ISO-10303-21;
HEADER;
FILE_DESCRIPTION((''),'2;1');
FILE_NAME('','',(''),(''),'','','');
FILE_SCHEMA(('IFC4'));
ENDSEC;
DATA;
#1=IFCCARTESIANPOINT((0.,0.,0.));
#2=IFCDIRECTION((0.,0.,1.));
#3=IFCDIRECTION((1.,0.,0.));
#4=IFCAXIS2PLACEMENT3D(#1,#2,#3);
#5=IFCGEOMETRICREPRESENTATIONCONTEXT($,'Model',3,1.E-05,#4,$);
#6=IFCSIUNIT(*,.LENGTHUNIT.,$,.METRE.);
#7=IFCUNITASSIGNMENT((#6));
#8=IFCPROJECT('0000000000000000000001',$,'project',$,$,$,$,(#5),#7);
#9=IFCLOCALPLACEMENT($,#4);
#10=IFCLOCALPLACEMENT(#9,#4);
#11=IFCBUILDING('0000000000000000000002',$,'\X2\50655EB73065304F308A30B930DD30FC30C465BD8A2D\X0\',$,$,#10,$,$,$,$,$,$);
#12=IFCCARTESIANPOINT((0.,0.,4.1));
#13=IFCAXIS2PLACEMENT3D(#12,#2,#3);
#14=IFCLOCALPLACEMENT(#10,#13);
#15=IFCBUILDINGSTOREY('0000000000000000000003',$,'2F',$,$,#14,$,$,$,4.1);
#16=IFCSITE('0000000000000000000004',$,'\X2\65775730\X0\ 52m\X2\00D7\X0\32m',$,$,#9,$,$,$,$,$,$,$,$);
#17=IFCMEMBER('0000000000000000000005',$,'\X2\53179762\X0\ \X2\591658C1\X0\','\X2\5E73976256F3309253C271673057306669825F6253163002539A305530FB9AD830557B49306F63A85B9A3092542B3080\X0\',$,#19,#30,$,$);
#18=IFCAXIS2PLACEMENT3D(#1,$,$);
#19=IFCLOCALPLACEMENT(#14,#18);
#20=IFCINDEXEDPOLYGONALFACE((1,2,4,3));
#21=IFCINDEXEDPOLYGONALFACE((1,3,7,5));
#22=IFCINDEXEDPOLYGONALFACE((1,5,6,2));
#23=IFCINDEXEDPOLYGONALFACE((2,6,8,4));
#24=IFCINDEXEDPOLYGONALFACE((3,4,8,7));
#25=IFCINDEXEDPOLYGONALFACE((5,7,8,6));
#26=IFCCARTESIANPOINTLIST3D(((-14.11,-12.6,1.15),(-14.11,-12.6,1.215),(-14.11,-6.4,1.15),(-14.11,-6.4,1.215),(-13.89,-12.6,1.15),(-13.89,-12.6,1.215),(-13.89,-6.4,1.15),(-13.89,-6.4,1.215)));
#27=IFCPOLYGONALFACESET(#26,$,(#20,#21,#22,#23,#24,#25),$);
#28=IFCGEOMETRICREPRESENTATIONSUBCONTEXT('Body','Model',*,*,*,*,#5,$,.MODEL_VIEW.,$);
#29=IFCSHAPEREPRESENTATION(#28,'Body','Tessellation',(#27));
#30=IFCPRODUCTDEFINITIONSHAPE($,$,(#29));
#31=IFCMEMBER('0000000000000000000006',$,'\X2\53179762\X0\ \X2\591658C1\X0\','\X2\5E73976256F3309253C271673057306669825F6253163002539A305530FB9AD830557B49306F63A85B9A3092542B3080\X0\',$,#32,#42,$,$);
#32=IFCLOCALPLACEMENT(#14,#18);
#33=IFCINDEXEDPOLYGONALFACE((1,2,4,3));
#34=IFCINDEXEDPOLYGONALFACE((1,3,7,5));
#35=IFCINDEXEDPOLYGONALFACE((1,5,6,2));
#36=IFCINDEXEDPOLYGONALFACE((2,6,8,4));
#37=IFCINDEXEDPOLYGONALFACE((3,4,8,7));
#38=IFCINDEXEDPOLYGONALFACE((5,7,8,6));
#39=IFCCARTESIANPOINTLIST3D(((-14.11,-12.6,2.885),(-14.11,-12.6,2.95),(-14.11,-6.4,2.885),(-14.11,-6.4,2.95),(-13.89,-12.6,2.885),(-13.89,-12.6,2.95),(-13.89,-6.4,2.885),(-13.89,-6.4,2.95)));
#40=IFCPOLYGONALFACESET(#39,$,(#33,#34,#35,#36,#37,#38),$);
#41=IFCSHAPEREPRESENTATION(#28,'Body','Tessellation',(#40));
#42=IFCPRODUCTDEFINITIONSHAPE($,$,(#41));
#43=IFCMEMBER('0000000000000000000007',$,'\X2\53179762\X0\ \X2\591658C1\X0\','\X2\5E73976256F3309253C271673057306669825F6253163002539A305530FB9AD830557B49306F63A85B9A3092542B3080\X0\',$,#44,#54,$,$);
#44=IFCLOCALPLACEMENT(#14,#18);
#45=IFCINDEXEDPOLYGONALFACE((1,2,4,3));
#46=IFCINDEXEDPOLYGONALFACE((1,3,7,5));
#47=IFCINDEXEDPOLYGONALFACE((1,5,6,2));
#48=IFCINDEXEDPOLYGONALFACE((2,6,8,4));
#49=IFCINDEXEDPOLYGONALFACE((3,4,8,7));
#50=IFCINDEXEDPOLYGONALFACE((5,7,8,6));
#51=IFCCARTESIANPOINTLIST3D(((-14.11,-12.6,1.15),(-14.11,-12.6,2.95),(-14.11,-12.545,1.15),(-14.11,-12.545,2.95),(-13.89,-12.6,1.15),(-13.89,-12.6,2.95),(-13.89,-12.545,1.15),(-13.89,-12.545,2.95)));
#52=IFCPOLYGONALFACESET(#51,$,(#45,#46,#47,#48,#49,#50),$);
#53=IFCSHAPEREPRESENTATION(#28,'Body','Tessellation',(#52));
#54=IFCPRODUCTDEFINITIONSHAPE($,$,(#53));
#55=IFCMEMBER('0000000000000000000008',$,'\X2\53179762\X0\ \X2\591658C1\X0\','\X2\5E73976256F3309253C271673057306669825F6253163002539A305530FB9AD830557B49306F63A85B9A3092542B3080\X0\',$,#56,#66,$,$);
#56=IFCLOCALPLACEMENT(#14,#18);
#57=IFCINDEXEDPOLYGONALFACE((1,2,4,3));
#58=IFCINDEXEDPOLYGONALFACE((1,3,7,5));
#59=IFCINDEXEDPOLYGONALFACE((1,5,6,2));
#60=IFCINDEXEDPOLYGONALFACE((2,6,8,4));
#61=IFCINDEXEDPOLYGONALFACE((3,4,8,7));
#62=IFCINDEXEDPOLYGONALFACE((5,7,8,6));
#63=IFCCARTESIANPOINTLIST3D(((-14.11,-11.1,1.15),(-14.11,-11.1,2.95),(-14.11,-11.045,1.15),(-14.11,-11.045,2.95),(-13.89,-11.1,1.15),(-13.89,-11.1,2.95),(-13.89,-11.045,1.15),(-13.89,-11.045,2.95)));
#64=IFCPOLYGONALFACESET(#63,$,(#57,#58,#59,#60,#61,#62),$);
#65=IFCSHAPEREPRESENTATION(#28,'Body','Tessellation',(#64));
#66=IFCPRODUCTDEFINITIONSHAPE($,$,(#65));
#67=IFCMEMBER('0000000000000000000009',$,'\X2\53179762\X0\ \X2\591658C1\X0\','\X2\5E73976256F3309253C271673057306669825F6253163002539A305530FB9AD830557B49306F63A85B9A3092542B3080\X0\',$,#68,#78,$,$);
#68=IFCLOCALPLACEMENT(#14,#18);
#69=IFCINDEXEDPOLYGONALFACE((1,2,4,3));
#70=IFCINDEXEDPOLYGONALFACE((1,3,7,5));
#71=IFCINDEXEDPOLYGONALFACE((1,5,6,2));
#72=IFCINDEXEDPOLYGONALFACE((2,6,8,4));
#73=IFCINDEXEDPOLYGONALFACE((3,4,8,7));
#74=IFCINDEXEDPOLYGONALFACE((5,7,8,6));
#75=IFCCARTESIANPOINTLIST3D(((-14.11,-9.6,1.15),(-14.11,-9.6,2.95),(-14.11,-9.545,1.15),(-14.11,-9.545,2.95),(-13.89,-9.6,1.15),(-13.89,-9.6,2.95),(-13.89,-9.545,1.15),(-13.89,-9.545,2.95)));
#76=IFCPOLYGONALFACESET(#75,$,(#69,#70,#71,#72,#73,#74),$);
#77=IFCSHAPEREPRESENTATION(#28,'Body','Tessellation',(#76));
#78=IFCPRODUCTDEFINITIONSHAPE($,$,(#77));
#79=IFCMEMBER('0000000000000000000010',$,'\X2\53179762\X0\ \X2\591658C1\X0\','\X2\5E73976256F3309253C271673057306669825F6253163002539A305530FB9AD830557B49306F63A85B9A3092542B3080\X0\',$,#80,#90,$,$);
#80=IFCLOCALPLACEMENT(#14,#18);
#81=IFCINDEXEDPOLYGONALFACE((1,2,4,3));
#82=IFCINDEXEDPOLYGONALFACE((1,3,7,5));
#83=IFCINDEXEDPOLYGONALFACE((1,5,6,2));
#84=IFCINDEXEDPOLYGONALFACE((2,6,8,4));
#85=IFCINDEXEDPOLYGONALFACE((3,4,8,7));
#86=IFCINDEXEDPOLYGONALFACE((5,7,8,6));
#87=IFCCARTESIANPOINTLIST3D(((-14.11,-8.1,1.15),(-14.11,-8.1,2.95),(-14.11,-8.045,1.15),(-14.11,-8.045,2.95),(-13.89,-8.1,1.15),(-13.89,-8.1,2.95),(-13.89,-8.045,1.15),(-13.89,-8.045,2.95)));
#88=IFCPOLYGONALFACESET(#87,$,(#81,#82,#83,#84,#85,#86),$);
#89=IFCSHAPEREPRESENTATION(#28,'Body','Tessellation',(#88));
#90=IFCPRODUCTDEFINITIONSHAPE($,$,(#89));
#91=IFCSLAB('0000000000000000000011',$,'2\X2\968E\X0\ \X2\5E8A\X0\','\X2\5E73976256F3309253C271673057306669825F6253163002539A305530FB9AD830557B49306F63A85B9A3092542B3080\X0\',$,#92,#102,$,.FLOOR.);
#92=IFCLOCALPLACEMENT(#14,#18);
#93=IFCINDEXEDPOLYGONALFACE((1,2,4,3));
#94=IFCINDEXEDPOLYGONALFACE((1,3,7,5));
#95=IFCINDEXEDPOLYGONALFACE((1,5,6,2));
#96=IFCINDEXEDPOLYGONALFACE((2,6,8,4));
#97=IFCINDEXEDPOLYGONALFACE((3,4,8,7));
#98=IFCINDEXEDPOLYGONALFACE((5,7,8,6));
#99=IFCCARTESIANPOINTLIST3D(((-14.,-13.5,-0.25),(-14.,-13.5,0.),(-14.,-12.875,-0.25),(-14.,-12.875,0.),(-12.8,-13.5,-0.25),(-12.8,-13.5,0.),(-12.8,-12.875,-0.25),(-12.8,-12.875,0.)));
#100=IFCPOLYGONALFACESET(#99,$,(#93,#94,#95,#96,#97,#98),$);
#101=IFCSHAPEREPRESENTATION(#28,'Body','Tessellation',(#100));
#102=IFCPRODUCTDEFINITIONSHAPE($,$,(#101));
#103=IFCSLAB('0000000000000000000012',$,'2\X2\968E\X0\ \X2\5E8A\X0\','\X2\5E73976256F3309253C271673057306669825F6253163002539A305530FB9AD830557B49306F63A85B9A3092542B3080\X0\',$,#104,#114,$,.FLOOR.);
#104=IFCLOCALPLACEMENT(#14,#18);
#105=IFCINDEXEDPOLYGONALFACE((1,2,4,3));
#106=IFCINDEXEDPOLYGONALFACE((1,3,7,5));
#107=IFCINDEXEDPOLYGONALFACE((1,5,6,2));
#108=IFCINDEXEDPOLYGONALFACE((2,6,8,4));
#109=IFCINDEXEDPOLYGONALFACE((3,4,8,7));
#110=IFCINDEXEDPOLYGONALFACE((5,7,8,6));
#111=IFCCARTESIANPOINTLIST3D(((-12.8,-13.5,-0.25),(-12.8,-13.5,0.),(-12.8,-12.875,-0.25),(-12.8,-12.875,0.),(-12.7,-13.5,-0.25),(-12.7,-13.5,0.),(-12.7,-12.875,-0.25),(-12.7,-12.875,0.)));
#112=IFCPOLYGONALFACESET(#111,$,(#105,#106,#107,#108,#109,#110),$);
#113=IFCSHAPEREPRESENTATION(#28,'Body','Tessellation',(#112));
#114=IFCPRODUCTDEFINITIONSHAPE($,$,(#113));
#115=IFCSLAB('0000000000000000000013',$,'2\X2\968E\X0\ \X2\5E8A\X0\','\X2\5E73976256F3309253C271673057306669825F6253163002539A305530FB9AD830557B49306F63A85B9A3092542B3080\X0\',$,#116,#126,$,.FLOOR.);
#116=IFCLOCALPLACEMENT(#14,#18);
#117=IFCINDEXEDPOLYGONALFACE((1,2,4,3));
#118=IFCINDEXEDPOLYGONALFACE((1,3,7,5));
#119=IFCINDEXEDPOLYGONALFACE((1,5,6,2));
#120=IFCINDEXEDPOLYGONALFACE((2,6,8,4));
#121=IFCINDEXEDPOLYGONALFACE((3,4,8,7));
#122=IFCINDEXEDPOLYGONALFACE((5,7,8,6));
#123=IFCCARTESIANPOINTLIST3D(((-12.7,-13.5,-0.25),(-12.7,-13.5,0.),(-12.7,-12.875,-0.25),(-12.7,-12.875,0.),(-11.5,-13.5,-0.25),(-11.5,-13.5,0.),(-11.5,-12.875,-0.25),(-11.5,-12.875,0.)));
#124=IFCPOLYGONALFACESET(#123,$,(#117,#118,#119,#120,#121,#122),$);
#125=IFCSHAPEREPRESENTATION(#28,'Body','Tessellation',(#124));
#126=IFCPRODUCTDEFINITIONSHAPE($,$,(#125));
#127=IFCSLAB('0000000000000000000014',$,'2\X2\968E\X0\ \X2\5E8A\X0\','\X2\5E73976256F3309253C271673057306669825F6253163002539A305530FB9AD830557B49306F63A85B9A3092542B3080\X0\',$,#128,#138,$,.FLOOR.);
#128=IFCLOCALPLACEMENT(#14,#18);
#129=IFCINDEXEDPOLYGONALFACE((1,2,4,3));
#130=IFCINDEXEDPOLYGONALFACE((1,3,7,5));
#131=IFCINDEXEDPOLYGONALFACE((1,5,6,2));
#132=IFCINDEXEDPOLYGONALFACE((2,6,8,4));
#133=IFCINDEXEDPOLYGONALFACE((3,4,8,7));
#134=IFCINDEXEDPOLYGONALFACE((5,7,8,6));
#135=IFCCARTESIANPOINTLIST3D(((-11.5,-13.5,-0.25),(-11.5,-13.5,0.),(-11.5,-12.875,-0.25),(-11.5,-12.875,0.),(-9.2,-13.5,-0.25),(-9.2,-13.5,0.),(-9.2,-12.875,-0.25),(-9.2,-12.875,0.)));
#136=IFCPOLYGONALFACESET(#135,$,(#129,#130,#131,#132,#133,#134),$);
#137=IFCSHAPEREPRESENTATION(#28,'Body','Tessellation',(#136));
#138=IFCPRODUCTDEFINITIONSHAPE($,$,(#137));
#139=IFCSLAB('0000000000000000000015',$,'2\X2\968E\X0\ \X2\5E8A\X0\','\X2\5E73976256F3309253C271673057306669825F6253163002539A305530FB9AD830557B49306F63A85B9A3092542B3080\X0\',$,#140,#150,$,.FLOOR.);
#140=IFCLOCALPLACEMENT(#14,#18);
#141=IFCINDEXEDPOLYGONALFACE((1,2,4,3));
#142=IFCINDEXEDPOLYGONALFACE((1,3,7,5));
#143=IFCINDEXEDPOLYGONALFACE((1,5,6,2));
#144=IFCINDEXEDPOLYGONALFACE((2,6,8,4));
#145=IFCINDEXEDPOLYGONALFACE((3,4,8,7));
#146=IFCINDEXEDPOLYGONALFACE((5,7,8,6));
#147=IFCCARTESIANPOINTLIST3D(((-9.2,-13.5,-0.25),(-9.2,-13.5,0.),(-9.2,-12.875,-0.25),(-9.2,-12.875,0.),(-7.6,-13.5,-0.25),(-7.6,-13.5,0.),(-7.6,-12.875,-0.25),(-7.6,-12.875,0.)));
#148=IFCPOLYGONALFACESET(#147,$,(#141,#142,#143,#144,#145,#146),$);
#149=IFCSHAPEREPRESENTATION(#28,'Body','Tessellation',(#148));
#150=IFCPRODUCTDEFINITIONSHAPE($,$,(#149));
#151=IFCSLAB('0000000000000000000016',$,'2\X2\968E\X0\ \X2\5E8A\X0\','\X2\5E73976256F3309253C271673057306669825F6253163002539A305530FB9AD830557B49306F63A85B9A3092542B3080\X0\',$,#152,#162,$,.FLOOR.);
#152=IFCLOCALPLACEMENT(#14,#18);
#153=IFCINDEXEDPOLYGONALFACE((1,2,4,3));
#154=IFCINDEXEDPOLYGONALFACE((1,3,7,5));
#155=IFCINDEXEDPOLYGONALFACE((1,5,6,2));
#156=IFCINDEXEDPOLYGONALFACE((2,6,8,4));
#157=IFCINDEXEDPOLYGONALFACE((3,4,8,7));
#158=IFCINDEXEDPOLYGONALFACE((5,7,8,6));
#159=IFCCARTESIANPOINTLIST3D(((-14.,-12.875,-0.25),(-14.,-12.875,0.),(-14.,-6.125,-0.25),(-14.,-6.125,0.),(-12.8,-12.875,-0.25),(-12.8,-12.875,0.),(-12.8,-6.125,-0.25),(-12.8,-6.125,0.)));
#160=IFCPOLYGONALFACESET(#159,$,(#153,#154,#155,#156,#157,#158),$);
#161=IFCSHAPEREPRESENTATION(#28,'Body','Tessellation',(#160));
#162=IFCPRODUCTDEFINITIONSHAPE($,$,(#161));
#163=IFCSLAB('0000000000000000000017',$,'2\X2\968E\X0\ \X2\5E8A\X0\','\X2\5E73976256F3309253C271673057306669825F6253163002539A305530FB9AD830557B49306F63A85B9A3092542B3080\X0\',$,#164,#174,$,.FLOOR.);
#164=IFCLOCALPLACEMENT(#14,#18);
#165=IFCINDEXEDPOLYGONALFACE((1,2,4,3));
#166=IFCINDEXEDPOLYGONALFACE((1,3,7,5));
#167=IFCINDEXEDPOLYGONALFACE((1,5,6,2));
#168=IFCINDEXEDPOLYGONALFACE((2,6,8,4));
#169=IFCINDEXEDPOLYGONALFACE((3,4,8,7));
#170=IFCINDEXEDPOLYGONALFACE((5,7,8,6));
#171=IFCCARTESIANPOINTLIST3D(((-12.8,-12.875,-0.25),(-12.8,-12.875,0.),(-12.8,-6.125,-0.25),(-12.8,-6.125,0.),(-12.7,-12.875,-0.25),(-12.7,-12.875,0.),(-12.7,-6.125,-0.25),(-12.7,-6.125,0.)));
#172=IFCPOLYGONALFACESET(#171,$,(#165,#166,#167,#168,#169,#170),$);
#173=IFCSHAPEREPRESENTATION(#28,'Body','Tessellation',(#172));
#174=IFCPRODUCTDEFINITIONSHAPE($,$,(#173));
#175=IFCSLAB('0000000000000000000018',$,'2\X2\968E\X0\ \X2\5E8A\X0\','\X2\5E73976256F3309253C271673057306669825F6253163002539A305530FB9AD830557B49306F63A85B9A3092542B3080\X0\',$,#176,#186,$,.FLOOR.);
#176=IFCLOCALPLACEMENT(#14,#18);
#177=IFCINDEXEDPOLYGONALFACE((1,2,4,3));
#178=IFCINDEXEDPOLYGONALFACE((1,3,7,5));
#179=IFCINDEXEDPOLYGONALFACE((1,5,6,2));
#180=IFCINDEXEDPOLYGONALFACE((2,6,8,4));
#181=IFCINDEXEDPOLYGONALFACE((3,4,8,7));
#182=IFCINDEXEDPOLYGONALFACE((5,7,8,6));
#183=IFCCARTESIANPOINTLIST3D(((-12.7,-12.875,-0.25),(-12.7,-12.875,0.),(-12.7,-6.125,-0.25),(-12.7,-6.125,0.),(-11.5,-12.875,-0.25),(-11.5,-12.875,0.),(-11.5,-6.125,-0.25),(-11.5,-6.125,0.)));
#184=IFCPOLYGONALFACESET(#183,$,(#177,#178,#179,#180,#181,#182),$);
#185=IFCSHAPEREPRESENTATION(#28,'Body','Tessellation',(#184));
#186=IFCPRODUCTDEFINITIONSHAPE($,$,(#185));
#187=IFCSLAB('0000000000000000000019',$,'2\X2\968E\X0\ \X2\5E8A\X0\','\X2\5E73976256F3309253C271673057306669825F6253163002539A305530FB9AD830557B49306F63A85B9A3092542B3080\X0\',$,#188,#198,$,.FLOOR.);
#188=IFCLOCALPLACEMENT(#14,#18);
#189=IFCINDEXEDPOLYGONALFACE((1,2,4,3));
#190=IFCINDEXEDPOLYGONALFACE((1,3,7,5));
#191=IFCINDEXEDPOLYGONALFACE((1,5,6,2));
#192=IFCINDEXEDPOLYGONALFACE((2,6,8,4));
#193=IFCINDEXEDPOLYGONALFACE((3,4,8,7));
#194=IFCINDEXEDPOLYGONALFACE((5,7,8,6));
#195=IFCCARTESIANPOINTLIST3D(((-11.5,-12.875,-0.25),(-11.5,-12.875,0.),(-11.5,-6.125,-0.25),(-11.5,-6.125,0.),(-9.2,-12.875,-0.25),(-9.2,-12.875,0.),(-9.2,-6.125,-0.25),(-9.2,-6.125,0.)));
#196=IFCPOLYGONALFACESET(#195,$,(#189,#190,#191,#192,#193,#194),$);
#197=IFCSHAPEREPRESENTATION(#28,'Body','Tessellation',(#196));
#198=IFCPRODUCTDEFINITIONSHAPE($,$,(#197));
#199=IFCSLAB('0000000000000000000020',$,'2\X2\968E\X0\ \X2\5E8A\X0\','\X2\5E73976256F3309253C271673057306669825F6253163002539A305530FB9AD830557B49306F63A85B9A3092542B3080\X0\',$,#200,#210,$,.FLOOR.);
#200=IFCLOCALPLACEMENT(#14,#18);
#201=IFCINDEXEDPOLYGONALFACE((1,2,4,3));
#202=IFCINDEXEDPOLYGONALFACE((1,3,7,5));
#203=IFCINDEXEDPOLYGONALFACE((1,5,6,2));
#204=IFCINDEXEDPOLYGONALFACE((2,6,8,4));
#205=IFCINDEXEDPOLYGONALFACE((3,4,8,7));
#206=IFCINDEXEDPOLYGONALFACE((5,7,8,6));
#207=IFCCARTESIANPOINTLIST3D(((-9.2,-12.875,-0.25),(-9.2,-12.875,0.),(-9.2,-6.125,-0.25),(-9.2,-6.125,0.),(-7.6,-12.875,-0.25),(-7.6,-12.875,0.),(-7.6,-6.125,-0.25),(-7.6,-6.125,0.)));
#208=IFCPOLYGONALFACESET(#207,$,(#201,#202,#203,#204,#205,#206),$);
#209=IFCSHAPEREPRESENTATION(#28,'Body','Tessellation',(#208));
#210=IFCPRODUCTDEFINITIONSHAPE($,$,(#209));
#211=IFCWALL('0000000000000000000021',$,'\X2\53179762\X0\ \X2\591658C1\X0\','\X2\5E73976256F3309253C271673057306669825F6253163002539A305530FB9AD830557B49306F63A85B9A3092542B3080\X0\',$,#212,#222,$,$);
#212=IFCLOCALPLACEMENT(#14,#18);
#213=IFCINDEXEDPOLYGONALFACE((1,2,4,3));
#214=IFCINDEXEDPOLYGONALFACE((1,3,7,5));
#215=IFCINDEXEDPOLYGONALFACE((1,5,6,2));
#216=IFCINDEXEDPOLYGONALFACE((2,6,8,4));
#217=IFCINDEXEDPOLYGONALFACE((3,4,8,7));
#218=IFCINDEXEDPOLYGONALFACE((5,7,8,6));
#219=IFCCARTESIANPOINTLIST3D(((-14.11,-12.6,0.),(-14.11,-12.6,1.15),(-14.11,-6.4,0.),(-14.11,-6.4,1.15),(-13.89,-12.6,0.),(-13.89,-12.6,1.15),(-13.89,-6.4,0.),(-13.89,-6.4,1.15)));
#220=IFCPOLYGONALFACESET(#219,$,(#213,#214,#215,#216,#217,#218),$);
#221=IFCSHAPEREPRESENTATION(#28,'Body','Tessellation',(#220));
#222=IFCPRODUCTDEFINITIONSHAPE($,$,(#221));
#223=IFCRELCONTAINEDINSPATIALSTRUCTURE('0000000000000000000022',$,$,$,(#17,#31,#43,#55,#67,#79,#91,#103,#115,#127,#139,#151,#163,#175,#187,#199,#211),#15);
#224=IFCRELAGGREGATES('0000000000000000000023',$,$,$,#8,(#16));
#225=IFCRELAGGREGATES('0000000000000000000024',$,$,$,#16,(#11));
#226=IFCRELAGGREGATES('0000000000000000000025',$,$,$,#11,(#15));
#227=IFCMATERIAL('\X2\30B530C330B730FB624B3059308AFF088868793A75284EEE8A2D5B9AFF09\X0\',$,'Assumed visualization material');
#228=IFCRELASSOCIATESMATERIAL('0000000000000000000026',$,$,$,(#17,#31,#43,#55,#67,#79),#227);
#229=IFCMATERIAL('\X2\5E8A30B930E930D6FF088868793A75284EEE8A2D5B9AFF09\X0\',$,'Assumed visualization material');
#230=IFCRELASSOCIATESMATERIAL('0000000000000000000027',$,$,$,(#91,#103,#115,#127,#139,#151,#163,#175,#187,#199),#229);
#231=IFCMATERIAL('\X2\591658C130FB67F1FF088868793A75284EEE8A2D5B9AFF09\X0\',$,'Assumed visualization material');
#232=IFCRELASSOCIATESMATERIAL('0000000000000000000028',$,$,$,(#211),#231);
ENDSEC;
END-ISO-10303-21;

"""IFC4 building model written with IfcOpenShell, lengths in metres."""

from ifc_helpers import new_model, si_unit, frame, origin_with_axes, place, context, subcontext, project, spatial, rectangle, extrude, material, element, save


model = new_model("IFC4")

# Units and contexts
model_context = context("Model", 3, precision=1e-05, world=origin_with_axes())
body_context = subcontext(model_context, "Body", "Model", "MODEL_VIEW")
ifc_project = project(units=[si_unit("LENGTHUNIT", "METRE")], contexts=[model_context])

# Site, building, storey
site_placement = place(None, origin_with_axes())
site = spatial("IfcSite", under=ifc_project, at=site_placement, Name="敷地 52m×32m")
building_placement = place(site_placement, origin_with_axes())
building = spatial("IfcBuilding", under=site, at=building_placement, Name="健康づくりスポーツ施設")
storey_placement = place(building_placement, frame((0.0, 0.0, 4.1), z_axis=(0.0, 0.0, 1.0), x_axis=(1.0, 0.0, 0.0)))
storey = spatial("IfcBuildingStorey", under=building, at=storey_placement, Name="2F", Elevation=4.1)

# Members
ifc_material_1 = material(Name="サッシ・手すり（表示用仮設定）", Category="Assumed visualization material")
for number, where, z_axis, x_axis, name in (
    (1, (-14.0, -9.5, 1.15), (0.0, 0.0, 1.0), (1.0, 0.0, 0.0), "北面 外壁"),
    (2, (-14.0, -9.5, 2.885), (0.0, 0.0, 1.0), (1.0, 0.0, 0.0), "北面 外壁"),
):
    element("IfcMember", number, at=place(storey_placement, frame(where, z_axis=z_axis, x_axis=x_axis)), inside=storey, material=ifc_material_1, Name=name, Description="平面図を参照して概形化。厚さ・高さ等は推定を含む", context=body_context, shape_type="SweptSolid", body=[
        extrude(rectangle(XDim=0.22, YDim=6.2), origin_with_axes(), (0.0, 0.0, 1.0), 0.065),
    ])
for number, where, z_axis, x_axis, name in (
    (3, (-14.0, -12.5725, 1.15), (0.0, 0.0, 1.0), (1.0, 0.0, 0.0), "北面 外壁"),
    (4, (-14.0, -11.0725, 1.15), (0.0, 0.0, 1.0), (1.0, 0.0, 0.0), "北面 外壁"),
    (5, (-14.0, -9.5725, 1.15), (0.0, 0.0, 1.0), (1.0, 0.0, 0.0), "北面 外壁"),
    (6, (-14.0, -8.0725, 1.15), (0.0, 0.0, 1.0), (1.0, 0.0, 0.0), "北面 外壁"),
):
    element("IfcMember", number, at=place(storey_placement, frame(where, z_axis=z_axis, x_axis=x_axis)), inside=storey, material=ifc_material_1, Name=name, Description="平面図を参照して概形化。厚さ・高さ等は推定を含む", context=body_context, shape_type="SweptSolid", body=[
        extrude(rectangle(XDim=0.22, YDim=0.055), origin_with_axes(), (0.0, 0.0, 1.0), 1.8),
    ])

# Slabs
ifc_material_2 = material(Name="床スラブ（表示用仮設定）", Category="Assumed visualization material")
slab_1_placement = place(storey_placement, frame((-13.4, -13.1875, -0.25), z_axis=(0.0, 0.0, 1.0), x_axis=(1.0, 0.0, 0.0)))
element("IfcSlab", 7, at=slab_1_placement, inside=storey, material=ifc_material_2, Name="2階 床", Description="平面図を参照して概形化。厚さ・高さ等は推定を含む", PredefinedType="FLOOR", context=body_context, shape_type="SweptSolid", body=[
    extrude(rectangle(XDim=1.2, YDim=0.625), origin_with_axes(), (0.0, 0.0, 1.0), 0.25),
])
slab_2_placement = place(storey_placement, frame((-12.75, -13.1875, -0.25), z_axis=(0.0, 0.0, 1.0), x_axis=(1.0, 0.0, 0.0)))
element("IfcSlab", 8, at=slab_2_placement, inside=storey, material=ifc_material_2, Name="2階 床", Description="平面図を参照して概形化。厚さ・高さ等は推定を含む", PredefinedType="FLOOR", context=body_context, shape_type="SweptSolid", body=[
    extrude(rectangle(XDim=0.1, YDim=0.625), origin_with_axes(), (0.0, 0.0, 1.0), 0.25),
])
slab_3_placement = place(storey_placement, frame((-12.1, -13.1875, -0.25), z_axis=(0.0, 0.0, 1.0), x_axis=(1.0, 0.0, 0.0)))
element("IfcSlab", 9, at=slab_3_placement, inside=storey, material=ifc_material_2, Name="2階 床", Description="平面図を参照して概形化。厚さ・高さ等は推定を含む", PredefinedType="FLOOR", context=body_context, shape_type="SweptSolid", body=[
    extrude(rectangle(XDim=1.2, YDim=0.625), origin_with_axes(), (0.0, 0.0, 1.0), 0.25),
])
slab_4_placement = place(storey_placement, frame((-10.35, -13.1875, -0.25), z_axis=(0.0, 0.0, 1.0), x_axis=(1.0, 0.0, 0.0)))
element("IfcSlab", 10, at=slab_4_placement, inside=storey, material=ifc_material_2, Name="2階 床", Description="平面図を参照して概形化。厚さ・高さ等は推定を含む", PredefinedType="FLOOR", context=body_context, shape_type="SweptSolid", body=[
    extrude(rectangle(XDim=2.3, YDim=0.625), origin_with_axes(), (0.0, 0.0, 1.0), 0.25),
])
slab_5_placement = place(storey_placement, frame((-8.4, -13.1875, -0.25), z_axis=(0.0, 0.0, 1.0), x_axis=(1.0, 0.0, 0.0)))
element("IfcSlab", 11, at=slab_5_placement, inside=storey, material=ifc_material_2, Name="2階 床", Description="平面図を参照して概形化。厚さ・高さ等は推定を含む", PredefinedType="FLOOR", context=body_context, shape_type="SweptSolid", body=[
    extrude(rectangle(XDim=1.6, YDim=0.625), origin_with_axes(), (0.0, 0.0, 1.0), 0.25),
])
slab_6_placement = place(storey_placement, frame((-13.4, -9.5, -0.25), z_axis=(0.0, 0.0, 1.0), x_axis=(1.0, 0.0, 0.0)))
element("IfcSlab", 12, at=slab_6_placement, inside=storey, material=ifc_material_2, Name="2階 床", Description="平面図を参照して概形化。厚さ・高さ等は推定を含む", PredefinedType="FLOOR", context=body_context, shape_type="SweptSolid", body=[
    extrude(rectangle(XDim=1.2, YDim=6.75), origin_with_axes(), (0.0, 0.0, 1.0), 0.25),
])
slab_7_placement = place(storey_placement, frame((-12.75, -9.5, -0.25), z_axis=(0.0, 0.0, 1.0), x_axis=(1.0, 0.0, 0.0)))
element("IfcSlab", 13, at=slab_7_placement, inside=storey, material=ifc_material_2, Name="2階 床", Description="平面図を参照して概形化。厚さ・高さ等は推定を含む", PredefinedType="FLOOR", context=body_context, shape_type="SweptSolid", body=[
    extrude(rectangle(XDim=0.1, YDim=6.75), origin_with_axes(), (0.0, 0.0, 1.0), 0.25),
])
slab_8_placement = place(storey_placement, frame((-12.1, -9.5, -0.25), z_axis=(0.0, 0.0, 1.0), x_axis=(1.0, 0.0, 0.0)))
element("IfcSlab", 14, at=slab_8_placement, inside=storey, material=ifc_material_2, Name="2階 床", Description="平面図を参照して概形化。厚さ・高さ等は推定を含む", PredefinedType="FLOOR", context=body_context, shape_type="SweptSolid", body=[
    extrude(rectangle(XDim=1.2, YDim=6.75), origin_with_axes(), (0.0, 0.0, 1.0), 0.25),
])
slab_9_placement = place(storey_placement, frame((-10.35, -9.5, -0.25), z_axis=(0.0, 0.0, 1.0), x_axis=(1.0, 0.0, 0.0)))
element("IfcSlab", 15, at=slab_9_placement, inside=storey, material=ifc_material_2, Name="2階 床", Description="平面図を参照して概形化。厚さ・高さ等は推定を含む", PredefinedType="FLOOR", context=body_context, shape_type="SweptSolid", body=[
    extrude(rectangle(XDim=2.3, YDim=6.75), origin_with_axes(), (0.0, 0.0, 1.0), 0.25),
])
slab_10_placement = place(storey_placement, frame((-8.4, -9.5, -0.25), z_axis=(0.0, 0.0, 1.0), x_axis=(1.0, 0.0, 0.0)))
element("IfcSlab", 16, at=slab_10_placement, inside=storey, material=ifc_material_2, Name="2階 床", Description="平面図を参照して概形化。厚さ・高さ等は推定を含む", PredefinedType="FLOOR", context=body_context, shape_type="SweptSolid", body=[
    extrude(rectangle(XDim=1.6, YDim=6.75), origin_with_axes(), (0.0, 0.0, 1.0), 0.25),
])

# Wall
ifc_material_3 = material(Name="外壁・柱（表示用仮設定）", Category="Assumed visualization material")
wall_1_placement = place(storey_placement, frame((-14.0, -9.5, 0.0), z_axis=(0.0, 0.0, 1.0), x_axis=(1.0, 0.0, 0.0)))
element("IfcWall", 17, at=wall_1_placement, inside=storey, material=ifc_material_3, Name="北面 外壁", Description="平面図を参照して概形化。厚さ・高さ等は推定を含む", context=body_context, shape_type="SweptSolid", body=[
    extrude(rectangle(XDim=0.22, YDim=6.2), origin_with_axes(), (0.0, 0.0, 1.0), 1.15),
])

save(model, "model.ifc")
